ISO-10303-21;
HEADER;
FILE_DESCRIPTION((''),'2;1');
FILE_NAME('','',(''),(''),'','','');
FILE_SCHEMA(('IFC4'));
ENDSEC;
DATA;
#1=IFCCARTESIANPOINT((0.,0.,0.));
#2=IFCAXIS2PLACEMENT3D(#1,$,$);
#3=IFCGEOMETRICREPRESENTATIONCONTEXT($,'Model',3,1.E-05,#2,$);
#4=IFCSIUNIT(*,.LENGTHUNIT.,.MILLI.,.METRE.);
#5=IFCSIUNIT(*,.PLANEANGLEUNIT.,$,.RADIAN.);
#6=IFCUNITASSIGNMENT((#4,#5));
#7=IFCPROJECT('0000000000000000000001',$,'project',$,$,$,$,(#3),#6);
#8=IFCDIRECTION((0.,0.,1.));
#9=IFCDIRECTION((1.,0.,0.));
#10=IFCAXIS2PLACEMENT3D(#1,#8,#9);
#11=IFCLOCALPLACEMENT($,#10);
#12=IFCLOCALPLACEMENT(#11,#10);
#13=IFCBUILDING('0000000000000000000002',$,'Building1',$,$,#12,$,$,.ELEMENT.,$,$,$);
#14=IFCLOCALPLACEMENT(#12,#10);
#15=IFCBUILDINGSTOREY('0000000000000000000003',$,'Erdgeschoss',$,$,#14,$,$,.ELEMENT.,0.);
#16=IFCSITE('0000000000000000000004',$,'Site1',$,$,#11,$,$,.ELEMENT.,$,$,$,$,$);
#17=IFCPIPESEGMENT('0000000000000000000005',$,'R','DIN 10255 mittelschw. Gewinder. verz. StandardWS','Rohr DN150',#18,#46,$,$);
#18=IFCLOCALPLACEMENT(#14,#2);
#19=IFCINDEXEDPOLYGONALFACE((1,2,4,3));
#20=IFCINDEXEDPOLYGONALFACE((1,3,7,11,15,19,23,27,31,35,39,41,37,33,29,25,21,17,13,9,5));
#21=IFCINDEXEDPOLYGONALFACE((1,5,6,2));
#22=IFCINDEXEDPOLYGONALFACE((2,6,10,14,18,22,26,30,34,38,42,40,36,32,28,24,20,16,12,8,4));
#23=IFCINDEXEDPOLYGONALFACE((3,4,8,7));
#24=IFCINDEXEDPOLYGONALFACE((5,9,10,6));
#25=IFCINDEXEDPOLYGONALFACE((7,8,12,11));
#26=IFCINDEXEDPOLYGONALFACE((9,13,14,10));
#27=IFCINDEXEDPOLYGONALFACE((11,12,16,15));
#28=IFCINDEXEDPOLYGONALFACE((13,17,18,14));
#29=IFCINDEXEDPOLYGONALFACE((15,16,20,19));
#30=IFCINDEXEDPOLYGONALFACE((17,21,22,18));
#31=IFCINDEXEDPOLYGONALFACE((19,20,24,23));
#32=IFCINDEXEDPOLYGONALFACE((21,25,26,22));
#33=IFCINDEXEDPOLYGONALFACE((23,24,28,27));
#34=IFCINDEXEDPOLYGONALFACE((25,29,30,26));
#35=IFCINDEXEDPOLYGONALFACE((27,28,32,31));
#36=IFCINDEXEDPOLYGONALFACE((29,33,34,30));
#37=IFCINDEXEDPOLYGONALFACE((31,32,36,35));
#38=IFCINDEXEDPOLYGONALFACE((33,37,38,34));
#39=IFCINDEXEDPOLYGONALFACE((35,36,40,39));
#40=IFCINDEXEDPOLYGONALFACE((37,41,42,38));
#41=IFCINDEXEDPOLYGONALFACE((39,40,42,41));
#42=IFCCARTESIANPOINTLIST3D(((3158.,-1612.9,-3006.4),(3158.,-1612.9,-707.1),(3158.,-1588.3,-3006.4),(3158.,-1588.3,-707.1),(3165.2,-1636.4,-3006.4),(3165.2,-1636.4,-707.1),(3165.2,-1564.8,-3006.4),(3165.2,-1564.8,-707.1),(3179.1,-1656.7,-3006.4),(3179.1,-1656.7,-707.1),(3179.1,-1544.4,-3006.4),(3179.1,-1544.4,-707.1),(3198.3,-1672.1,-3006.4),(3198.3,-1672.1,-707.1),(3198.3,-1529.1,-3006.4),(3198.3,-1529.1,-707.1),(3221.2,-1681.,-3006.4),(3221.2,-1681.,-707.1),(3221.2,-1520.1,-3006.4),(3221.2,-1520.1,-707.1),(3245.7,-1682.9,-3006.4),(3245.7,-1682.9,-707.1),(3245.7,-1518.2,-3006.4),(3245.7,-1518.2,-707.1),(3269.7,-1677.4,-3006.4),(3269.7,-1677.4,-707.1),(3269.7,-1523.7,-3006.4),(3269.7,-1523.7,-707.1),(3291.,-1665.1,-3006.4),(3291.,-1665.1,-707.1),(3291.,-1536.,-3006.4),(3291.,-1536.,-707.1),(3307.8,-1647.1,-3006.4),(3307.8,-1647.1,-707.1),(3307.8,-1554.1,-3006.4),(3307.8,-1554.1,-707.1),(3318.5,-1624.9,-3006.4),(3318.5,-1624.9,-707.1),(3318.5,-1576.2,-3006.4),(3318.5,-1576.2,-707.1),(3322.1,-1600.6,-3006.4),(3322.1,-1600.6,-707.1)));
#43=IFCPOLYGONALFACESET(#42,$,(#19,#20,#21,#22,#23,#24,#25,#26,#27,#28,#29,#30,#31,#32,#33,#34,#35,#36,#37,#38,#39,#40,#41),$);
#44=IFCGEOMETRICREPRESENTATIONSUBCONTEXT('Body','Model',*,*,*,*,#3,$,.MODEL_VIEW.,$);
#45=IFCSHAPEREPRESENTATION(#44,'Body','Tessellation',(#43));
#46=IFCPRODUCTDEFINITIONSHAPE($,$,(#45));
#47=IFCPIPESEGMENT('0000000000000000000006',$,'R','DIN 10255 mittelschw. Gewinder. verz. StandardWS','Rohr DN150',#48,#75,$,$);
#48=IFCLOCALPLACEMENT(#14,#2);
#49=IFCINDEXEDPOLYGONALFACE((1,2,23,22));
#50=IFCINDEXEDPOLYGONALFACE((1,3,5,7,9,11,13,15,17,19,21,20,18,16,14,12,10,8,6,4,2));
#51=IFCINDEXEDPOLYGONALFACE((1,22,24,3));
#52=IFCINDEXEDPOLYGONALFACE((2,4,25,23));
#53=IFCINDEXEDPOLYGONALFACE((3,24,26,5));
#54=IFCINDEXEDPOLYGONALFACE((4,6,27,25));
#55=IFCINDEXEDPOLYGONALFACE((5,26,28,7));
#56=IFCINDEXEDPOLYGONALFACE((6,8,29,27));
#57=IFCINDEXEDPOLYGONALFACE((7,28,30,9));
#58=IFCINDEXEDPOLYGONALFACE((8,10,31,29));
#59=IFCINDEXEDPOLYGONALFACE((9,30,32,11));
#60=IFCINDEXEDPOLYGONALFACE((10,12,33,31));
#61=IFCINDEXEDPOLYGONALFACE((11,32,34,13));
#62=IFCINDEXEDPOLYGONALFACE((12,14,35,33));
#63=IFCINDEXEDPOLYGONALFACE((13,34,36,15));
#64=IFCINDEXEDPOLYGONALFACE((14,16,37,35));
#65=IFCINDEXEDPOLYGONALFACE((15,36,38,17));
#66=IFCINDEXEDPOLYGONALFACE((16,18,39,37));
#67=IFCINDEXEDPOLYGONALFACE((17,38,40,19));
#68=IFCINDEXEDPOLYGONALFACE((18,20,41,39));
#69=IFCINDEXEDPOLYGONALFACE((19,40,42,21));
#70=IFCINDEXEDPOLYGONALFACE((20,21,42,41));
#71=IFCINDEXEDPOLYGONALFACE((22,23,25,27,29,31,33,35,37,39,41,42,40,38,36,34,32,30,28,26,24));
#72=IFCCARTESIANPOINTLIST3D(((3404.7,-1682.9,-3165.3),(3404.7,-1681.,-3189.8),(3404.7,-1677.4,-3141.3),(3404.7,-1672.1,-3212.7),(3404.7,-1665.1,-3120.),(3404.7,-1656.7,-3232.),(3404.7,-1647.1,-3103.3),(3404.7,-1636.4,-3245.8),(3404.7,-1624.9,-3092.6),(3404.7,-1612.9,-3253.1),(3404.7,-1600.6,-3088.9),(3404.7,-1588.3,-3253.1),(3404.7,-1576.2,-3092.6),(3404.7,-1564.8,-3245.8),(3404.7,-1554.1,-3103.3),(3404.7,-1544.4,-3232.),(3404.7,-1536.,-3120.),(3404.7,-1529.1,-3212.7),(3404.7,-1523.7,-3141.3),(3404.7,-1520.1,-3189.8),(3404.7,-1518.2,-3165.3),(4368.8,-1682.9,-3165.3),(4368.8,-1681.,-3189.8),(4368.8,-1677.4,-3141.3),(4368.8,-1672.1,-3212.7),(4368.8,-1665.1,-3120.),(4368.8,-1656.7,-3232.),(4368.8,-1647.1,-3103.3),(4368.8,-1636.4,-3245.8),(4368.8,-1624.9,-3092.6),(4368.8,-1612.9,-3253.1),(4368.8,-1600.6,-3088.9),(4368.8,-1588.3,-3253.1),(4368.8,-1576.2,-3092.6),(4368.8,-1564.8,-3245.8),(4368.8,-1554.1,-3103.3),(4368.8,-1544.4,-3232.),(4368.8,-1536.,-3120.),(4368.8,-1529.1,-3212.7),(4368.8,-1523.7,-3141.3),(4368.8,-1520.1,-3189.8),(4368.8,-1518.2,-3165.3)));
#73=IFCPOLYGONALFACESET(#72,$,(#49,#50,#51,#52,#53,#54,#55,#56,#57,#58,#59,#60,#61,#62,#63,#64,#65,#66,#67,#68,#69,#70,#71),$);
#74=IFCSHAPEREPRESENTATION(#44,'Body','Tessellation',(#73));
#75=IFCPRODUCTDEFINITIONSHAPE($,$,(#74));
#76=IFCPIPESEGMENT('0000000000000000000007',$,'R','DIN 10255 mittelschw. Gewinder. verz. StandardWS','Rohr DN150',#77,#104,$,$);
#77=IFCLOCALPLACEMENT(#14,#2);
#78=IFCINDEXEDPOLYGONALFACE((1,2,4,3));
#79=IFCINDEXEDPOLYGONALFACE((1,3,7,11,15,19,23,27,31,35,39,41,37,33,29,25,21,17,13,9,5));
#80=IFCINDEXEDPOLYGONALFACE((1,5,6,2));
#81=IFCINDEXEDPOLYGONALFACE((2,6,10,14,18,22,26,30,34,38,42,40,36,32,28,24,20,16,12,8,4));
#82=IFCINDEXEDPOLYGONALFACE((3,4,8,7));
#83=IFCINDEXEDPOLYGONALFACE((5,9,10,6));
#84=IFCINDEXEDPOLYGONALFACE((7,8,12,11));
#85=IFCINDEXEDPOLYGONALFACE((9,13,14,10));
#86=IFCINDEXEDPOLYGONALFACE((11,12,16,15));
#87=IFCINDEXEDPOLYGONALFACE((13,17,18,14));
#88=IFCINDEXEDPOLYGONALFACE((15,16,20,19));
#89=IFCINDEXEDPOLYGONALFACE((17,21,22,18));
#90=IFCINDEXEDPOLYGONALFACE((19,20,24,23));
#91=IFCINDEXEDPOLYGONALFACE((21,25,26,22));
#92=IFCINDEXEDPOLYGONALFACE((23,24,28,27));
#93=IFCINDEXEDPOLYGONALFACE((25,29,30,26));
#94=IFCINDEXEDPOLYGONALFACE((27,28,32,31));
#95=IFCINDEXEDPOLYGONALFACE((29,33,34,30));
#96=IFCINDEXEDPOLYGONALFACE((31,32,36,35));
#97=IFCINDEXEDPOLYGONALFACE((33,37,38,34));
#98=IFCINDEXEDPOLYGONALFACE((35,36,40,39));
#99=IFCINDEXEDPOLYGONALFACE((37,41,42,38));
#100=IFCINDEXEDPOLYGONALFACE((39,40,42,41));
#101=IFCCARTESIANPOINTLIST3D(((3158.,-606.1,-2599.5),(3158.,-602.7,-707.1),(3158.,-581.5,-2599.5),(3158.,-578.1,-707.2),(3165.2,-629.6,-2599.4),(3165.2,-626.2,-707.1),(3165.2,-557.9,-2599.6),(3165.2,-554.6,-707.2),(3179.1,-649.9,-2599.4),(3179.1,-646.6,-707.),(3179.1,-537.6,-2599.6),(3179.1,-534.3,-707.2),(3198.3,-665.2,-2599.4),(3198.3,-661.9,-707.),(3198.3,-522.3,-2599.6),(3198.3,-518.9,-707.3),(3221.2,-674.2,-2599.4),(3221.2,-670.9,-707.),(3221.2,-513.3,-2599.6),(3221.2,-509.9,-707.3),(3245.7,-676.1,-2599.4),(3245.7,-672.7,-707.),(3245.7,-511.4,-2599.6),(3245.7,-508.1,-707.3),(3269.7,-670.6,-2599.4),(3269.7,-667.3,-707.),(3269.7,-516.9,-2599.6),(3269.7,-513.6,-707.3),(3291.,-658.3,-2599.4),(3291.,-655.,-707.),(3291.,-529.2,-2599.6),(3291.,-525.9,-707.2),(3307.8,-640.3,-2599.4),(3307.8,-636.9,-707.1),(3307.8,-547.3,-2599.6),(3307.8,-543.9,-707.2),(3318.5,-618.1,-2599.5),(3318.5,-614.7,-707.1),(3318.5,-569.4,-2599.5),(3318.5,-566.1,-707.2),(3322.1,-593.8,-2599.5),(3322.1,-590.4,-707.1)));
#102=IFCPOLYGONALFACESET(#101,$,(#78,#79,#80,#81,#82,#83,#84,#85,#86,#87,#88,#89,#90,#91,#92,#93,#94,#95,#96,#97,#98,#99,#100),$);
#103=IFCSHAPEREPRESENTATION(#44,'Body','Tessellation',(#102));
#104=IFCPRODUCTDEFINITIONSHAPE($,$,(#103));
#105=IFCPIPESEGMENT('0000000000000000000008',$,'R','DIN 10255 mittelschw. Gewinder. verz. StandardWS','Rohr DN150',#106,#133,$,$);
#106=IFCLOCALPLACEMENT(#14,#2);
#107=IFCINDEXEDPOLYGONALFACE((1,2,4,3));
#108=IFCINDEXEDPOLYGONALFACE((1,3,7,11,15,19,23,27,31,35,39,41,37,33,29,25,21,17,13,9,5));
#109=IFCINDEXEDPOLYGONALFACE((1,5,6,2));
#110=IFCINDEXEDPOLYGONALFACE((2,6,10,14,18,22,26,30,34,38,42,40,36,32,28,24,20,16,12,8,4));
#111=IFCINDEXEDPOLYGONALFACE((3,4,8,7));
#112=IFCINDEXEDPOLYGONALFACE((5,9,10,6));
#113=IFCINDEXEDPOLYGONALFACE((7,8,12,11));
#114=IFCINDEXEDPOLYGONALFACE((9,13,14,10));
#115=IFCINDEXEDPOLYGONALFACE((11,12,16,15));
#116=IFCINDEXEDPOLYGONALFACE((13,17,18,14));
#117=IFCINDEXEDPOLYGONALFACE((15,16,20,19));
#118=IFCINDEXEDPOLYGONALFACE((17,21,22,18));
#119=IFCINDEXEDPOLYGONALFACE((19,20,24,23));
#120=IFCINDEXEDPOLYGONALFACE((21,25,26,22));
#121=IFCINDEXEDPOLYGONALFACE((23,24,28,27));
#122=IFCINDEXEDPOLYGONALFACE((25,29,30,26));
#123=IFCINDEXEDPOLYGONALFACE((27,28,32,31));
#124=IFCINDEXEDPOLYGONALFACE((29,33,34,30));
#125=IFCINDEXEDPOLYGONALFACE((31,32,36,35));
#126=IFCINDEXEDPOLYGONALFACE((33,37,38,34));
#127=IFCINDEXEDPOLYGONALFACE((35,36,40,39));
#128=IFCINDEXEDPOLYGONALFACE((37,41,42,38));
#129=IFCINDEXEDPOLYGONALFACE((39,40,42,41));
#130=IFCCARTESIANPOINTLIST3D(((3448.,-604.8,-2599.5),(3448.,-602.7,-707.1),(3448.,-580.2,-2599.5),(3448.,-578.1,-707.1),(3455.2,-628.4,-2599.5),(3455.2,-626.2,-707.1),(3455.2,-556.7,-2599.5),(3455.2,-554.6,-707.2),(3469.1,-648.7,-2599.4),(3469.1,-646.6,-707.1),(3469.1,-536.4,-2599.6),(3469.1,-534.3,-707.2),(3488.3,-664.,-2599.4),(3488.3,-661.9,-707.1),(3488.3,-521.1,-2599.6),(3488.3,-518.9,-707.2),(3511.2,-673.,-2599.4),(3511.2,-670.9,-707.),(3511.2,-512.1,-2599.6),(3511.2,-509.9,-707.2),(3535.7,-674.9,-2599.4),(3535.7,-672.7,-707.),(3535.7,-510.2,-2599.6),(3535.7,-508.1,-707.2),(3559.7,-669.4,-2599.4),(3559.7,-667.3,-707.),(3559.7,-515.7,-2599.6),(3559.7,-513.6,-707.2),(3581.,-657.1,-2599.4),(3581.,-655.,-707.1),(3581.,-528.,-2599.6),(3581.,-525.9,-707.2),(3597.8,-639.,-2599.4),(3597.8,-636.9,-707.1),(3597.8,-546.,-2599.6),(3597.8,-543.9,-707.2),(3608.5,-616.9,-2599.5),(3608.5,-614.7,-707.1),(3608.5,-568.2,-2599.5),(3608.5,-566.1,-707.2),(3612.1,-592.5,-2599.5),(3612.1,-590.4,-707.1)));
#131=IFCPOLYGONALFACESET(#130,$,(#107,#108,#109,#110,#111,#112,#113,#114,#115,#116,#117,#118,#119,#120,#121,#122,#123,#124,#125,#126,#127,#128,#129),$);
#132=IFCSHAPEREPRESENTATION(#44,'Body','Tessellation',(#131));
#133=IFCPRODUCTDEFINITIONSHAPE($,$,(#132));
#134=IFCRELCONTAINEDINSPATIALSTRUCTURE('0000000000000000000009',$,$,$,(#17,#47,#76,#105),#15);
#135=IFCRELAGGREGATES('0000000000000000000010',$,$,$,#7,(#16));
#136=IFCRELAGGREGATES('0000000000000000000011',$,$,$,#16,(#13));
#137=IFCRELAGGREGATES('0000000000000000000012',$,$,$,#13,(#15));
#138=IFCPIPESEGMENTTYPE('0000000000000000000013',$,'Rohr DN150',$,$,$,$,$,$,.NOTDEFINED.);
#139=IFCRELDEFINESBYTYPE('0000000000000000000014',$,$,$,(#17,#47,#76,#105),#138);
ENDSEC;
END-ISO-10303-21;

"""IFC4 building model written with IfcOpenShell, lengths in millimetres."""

from ifc_helpers import new_model, si_unit, frame, origin, origin_with_axes, origin_2d_with_axis, place, context, subcontext, project, spatial, circle, extrude, type_object, element, save


model = new_model("IFC4")

# Units and contexts
model_context = context("Model", 3, precision=1e-05, world=origin())
body_context = subcontext(model_context, "Body", "Model", "MODEL_VIEW")
ifc_project = project(units=[si_unit("LENGTHUNIT", "METRE", prefix="MILLI"), si_unit("PLANEANGLEUNIT", "RADIAN")], contexts=[model_context])

# Site, building, storey
site_placement = place(None, origin_with_axes())
site = spatial("IfcSite", under=ifc_project, at=site_placement, Name="Site1", CompositionType="ELEMENT")
building_placement = place(site_placement, origin_with_axes())
building = spatial("IfcBuilding", under=site, at=building_placement, Name="Building1", CompositionType="ELEMENT")
storey_placement = place(building_placement, origin_with_axes())
storey = spatial("IfcBuildingStorey", under=building, at=storey_placement, Name="Erdgeschoss", CompositionType="ELEMENT", Elevation=0.0)

# Pipe segments
pipe_segment_type_1 = type_object("IfcPipeSegmentType", Name="Rohr DN150", PredefinedType="NOTDEFINED")
pipe_segment_1_placement = place(storey_placement, frame((3239.6, -1600.4, -1856.8), z_axis=(0.0, 0.0, 1.0), x_axis=(1.0, 0.0, 0.0)))
element("IfcPipeSegment", 1, at=pipe_segment_1_placement, inside=storey, type_object=pipe_segment_type_1, Name="R", Description="DIN 10255 mittelschw. Gewinder. verz. StandardWS", ObjectType="Rohr DN150", context=body_context, shape_type="SolidModel", body=[
    extrude(circle(Radius=82.5, at=origin_2d_with_axis()), frame((0.0, -0.2, 1149.6), z_axis=(0.0, 0.0, -1.0), x_axis=(1.0, 0.0, 0.0)), (0.0, 0.0, 1.0), 2299.2),
])
pipe_segment_2_placement = place(storey_placement, frame((3886.8, -1600.7, -3171.5), z_axis=(0.0, 0.0, 1.0), x_axis=(1.0, 0.0, 0.0)))
element("IfcPipeSegment", 2, at=pipe_segment_2_placement, inside=storey, type_object=pipe_segment_type_1, Name="R", Description="DIN 10255 mittelschw. Gewinder. verz. StandardWS", ObjectType="Rohr DN150", context=body_context, shape_type="SolidModel", body=[
    extrude(circle(Radius=82.5, at=origin_2d_with_axis()), frame((482.1, 0.1, 0.0), z_axis=(-1.0, 0.0, 0.0), x_axis=(0.0, 0.0, 1.0)), (0.0, 0.0, 1.0), 964.1),
])
pipe_segment_3_placement = place(storey_placement, frame((3239.6, -592.2, -1653.3), z_axis=(0.0, 0.0, 1.0), x_axis=(1.0, 0.0, 0.0)))
element("IfcPipeSegment", 3, at=pipe_segment_3_placement, inside=storey, type_object=pipe_segment_type_1, Name="R", Description="DIN 10255 mittelschw. Gewinder. verz. StandardWS", ObjectType="Rohr DN150", context=body_context, shape_type="SolidModel", body=[
    extrude(circle(Radius=82.5, at=origin_2d_with_axis()), frame((0.0, -1.5, -946.2), z_axis=(0.0, 0.001768, 0.999998), x_axis=(1.0, 0.0, 0.0)), (0.0, 0.0, 1.0), 1892.4),
])
pipe_segment_4_placement = place(storey_placement, frame((3529.6, -591.6, -1653.3), z_axis=(0.0, 0.0, 1.0), x_axis=(1.0, 0.0, 0.0)))
element("IfcPipeSegment", 4, at=pipe_segment_4_placement, inside=storey, type_object=pipe_segment_type_1, Name="R", Description="DIN 10255 mittelschw. Gewinder. verz. StandardWS", ObjectType="Rohr DN150", context=body_context, shape_type="SolidModel", body=[
    extrude(circle(Radius=82.5, at=origin_2d_with_axis()), frame((0.0, -0.9, -946.2), z_axis=(0.0, 0.001126, 0.999999), x_axis=(1.0, 0.0, 0.0)), (0.0, 0.0, 1.0), 1892.4),
])

save(model, "model.ifc")
